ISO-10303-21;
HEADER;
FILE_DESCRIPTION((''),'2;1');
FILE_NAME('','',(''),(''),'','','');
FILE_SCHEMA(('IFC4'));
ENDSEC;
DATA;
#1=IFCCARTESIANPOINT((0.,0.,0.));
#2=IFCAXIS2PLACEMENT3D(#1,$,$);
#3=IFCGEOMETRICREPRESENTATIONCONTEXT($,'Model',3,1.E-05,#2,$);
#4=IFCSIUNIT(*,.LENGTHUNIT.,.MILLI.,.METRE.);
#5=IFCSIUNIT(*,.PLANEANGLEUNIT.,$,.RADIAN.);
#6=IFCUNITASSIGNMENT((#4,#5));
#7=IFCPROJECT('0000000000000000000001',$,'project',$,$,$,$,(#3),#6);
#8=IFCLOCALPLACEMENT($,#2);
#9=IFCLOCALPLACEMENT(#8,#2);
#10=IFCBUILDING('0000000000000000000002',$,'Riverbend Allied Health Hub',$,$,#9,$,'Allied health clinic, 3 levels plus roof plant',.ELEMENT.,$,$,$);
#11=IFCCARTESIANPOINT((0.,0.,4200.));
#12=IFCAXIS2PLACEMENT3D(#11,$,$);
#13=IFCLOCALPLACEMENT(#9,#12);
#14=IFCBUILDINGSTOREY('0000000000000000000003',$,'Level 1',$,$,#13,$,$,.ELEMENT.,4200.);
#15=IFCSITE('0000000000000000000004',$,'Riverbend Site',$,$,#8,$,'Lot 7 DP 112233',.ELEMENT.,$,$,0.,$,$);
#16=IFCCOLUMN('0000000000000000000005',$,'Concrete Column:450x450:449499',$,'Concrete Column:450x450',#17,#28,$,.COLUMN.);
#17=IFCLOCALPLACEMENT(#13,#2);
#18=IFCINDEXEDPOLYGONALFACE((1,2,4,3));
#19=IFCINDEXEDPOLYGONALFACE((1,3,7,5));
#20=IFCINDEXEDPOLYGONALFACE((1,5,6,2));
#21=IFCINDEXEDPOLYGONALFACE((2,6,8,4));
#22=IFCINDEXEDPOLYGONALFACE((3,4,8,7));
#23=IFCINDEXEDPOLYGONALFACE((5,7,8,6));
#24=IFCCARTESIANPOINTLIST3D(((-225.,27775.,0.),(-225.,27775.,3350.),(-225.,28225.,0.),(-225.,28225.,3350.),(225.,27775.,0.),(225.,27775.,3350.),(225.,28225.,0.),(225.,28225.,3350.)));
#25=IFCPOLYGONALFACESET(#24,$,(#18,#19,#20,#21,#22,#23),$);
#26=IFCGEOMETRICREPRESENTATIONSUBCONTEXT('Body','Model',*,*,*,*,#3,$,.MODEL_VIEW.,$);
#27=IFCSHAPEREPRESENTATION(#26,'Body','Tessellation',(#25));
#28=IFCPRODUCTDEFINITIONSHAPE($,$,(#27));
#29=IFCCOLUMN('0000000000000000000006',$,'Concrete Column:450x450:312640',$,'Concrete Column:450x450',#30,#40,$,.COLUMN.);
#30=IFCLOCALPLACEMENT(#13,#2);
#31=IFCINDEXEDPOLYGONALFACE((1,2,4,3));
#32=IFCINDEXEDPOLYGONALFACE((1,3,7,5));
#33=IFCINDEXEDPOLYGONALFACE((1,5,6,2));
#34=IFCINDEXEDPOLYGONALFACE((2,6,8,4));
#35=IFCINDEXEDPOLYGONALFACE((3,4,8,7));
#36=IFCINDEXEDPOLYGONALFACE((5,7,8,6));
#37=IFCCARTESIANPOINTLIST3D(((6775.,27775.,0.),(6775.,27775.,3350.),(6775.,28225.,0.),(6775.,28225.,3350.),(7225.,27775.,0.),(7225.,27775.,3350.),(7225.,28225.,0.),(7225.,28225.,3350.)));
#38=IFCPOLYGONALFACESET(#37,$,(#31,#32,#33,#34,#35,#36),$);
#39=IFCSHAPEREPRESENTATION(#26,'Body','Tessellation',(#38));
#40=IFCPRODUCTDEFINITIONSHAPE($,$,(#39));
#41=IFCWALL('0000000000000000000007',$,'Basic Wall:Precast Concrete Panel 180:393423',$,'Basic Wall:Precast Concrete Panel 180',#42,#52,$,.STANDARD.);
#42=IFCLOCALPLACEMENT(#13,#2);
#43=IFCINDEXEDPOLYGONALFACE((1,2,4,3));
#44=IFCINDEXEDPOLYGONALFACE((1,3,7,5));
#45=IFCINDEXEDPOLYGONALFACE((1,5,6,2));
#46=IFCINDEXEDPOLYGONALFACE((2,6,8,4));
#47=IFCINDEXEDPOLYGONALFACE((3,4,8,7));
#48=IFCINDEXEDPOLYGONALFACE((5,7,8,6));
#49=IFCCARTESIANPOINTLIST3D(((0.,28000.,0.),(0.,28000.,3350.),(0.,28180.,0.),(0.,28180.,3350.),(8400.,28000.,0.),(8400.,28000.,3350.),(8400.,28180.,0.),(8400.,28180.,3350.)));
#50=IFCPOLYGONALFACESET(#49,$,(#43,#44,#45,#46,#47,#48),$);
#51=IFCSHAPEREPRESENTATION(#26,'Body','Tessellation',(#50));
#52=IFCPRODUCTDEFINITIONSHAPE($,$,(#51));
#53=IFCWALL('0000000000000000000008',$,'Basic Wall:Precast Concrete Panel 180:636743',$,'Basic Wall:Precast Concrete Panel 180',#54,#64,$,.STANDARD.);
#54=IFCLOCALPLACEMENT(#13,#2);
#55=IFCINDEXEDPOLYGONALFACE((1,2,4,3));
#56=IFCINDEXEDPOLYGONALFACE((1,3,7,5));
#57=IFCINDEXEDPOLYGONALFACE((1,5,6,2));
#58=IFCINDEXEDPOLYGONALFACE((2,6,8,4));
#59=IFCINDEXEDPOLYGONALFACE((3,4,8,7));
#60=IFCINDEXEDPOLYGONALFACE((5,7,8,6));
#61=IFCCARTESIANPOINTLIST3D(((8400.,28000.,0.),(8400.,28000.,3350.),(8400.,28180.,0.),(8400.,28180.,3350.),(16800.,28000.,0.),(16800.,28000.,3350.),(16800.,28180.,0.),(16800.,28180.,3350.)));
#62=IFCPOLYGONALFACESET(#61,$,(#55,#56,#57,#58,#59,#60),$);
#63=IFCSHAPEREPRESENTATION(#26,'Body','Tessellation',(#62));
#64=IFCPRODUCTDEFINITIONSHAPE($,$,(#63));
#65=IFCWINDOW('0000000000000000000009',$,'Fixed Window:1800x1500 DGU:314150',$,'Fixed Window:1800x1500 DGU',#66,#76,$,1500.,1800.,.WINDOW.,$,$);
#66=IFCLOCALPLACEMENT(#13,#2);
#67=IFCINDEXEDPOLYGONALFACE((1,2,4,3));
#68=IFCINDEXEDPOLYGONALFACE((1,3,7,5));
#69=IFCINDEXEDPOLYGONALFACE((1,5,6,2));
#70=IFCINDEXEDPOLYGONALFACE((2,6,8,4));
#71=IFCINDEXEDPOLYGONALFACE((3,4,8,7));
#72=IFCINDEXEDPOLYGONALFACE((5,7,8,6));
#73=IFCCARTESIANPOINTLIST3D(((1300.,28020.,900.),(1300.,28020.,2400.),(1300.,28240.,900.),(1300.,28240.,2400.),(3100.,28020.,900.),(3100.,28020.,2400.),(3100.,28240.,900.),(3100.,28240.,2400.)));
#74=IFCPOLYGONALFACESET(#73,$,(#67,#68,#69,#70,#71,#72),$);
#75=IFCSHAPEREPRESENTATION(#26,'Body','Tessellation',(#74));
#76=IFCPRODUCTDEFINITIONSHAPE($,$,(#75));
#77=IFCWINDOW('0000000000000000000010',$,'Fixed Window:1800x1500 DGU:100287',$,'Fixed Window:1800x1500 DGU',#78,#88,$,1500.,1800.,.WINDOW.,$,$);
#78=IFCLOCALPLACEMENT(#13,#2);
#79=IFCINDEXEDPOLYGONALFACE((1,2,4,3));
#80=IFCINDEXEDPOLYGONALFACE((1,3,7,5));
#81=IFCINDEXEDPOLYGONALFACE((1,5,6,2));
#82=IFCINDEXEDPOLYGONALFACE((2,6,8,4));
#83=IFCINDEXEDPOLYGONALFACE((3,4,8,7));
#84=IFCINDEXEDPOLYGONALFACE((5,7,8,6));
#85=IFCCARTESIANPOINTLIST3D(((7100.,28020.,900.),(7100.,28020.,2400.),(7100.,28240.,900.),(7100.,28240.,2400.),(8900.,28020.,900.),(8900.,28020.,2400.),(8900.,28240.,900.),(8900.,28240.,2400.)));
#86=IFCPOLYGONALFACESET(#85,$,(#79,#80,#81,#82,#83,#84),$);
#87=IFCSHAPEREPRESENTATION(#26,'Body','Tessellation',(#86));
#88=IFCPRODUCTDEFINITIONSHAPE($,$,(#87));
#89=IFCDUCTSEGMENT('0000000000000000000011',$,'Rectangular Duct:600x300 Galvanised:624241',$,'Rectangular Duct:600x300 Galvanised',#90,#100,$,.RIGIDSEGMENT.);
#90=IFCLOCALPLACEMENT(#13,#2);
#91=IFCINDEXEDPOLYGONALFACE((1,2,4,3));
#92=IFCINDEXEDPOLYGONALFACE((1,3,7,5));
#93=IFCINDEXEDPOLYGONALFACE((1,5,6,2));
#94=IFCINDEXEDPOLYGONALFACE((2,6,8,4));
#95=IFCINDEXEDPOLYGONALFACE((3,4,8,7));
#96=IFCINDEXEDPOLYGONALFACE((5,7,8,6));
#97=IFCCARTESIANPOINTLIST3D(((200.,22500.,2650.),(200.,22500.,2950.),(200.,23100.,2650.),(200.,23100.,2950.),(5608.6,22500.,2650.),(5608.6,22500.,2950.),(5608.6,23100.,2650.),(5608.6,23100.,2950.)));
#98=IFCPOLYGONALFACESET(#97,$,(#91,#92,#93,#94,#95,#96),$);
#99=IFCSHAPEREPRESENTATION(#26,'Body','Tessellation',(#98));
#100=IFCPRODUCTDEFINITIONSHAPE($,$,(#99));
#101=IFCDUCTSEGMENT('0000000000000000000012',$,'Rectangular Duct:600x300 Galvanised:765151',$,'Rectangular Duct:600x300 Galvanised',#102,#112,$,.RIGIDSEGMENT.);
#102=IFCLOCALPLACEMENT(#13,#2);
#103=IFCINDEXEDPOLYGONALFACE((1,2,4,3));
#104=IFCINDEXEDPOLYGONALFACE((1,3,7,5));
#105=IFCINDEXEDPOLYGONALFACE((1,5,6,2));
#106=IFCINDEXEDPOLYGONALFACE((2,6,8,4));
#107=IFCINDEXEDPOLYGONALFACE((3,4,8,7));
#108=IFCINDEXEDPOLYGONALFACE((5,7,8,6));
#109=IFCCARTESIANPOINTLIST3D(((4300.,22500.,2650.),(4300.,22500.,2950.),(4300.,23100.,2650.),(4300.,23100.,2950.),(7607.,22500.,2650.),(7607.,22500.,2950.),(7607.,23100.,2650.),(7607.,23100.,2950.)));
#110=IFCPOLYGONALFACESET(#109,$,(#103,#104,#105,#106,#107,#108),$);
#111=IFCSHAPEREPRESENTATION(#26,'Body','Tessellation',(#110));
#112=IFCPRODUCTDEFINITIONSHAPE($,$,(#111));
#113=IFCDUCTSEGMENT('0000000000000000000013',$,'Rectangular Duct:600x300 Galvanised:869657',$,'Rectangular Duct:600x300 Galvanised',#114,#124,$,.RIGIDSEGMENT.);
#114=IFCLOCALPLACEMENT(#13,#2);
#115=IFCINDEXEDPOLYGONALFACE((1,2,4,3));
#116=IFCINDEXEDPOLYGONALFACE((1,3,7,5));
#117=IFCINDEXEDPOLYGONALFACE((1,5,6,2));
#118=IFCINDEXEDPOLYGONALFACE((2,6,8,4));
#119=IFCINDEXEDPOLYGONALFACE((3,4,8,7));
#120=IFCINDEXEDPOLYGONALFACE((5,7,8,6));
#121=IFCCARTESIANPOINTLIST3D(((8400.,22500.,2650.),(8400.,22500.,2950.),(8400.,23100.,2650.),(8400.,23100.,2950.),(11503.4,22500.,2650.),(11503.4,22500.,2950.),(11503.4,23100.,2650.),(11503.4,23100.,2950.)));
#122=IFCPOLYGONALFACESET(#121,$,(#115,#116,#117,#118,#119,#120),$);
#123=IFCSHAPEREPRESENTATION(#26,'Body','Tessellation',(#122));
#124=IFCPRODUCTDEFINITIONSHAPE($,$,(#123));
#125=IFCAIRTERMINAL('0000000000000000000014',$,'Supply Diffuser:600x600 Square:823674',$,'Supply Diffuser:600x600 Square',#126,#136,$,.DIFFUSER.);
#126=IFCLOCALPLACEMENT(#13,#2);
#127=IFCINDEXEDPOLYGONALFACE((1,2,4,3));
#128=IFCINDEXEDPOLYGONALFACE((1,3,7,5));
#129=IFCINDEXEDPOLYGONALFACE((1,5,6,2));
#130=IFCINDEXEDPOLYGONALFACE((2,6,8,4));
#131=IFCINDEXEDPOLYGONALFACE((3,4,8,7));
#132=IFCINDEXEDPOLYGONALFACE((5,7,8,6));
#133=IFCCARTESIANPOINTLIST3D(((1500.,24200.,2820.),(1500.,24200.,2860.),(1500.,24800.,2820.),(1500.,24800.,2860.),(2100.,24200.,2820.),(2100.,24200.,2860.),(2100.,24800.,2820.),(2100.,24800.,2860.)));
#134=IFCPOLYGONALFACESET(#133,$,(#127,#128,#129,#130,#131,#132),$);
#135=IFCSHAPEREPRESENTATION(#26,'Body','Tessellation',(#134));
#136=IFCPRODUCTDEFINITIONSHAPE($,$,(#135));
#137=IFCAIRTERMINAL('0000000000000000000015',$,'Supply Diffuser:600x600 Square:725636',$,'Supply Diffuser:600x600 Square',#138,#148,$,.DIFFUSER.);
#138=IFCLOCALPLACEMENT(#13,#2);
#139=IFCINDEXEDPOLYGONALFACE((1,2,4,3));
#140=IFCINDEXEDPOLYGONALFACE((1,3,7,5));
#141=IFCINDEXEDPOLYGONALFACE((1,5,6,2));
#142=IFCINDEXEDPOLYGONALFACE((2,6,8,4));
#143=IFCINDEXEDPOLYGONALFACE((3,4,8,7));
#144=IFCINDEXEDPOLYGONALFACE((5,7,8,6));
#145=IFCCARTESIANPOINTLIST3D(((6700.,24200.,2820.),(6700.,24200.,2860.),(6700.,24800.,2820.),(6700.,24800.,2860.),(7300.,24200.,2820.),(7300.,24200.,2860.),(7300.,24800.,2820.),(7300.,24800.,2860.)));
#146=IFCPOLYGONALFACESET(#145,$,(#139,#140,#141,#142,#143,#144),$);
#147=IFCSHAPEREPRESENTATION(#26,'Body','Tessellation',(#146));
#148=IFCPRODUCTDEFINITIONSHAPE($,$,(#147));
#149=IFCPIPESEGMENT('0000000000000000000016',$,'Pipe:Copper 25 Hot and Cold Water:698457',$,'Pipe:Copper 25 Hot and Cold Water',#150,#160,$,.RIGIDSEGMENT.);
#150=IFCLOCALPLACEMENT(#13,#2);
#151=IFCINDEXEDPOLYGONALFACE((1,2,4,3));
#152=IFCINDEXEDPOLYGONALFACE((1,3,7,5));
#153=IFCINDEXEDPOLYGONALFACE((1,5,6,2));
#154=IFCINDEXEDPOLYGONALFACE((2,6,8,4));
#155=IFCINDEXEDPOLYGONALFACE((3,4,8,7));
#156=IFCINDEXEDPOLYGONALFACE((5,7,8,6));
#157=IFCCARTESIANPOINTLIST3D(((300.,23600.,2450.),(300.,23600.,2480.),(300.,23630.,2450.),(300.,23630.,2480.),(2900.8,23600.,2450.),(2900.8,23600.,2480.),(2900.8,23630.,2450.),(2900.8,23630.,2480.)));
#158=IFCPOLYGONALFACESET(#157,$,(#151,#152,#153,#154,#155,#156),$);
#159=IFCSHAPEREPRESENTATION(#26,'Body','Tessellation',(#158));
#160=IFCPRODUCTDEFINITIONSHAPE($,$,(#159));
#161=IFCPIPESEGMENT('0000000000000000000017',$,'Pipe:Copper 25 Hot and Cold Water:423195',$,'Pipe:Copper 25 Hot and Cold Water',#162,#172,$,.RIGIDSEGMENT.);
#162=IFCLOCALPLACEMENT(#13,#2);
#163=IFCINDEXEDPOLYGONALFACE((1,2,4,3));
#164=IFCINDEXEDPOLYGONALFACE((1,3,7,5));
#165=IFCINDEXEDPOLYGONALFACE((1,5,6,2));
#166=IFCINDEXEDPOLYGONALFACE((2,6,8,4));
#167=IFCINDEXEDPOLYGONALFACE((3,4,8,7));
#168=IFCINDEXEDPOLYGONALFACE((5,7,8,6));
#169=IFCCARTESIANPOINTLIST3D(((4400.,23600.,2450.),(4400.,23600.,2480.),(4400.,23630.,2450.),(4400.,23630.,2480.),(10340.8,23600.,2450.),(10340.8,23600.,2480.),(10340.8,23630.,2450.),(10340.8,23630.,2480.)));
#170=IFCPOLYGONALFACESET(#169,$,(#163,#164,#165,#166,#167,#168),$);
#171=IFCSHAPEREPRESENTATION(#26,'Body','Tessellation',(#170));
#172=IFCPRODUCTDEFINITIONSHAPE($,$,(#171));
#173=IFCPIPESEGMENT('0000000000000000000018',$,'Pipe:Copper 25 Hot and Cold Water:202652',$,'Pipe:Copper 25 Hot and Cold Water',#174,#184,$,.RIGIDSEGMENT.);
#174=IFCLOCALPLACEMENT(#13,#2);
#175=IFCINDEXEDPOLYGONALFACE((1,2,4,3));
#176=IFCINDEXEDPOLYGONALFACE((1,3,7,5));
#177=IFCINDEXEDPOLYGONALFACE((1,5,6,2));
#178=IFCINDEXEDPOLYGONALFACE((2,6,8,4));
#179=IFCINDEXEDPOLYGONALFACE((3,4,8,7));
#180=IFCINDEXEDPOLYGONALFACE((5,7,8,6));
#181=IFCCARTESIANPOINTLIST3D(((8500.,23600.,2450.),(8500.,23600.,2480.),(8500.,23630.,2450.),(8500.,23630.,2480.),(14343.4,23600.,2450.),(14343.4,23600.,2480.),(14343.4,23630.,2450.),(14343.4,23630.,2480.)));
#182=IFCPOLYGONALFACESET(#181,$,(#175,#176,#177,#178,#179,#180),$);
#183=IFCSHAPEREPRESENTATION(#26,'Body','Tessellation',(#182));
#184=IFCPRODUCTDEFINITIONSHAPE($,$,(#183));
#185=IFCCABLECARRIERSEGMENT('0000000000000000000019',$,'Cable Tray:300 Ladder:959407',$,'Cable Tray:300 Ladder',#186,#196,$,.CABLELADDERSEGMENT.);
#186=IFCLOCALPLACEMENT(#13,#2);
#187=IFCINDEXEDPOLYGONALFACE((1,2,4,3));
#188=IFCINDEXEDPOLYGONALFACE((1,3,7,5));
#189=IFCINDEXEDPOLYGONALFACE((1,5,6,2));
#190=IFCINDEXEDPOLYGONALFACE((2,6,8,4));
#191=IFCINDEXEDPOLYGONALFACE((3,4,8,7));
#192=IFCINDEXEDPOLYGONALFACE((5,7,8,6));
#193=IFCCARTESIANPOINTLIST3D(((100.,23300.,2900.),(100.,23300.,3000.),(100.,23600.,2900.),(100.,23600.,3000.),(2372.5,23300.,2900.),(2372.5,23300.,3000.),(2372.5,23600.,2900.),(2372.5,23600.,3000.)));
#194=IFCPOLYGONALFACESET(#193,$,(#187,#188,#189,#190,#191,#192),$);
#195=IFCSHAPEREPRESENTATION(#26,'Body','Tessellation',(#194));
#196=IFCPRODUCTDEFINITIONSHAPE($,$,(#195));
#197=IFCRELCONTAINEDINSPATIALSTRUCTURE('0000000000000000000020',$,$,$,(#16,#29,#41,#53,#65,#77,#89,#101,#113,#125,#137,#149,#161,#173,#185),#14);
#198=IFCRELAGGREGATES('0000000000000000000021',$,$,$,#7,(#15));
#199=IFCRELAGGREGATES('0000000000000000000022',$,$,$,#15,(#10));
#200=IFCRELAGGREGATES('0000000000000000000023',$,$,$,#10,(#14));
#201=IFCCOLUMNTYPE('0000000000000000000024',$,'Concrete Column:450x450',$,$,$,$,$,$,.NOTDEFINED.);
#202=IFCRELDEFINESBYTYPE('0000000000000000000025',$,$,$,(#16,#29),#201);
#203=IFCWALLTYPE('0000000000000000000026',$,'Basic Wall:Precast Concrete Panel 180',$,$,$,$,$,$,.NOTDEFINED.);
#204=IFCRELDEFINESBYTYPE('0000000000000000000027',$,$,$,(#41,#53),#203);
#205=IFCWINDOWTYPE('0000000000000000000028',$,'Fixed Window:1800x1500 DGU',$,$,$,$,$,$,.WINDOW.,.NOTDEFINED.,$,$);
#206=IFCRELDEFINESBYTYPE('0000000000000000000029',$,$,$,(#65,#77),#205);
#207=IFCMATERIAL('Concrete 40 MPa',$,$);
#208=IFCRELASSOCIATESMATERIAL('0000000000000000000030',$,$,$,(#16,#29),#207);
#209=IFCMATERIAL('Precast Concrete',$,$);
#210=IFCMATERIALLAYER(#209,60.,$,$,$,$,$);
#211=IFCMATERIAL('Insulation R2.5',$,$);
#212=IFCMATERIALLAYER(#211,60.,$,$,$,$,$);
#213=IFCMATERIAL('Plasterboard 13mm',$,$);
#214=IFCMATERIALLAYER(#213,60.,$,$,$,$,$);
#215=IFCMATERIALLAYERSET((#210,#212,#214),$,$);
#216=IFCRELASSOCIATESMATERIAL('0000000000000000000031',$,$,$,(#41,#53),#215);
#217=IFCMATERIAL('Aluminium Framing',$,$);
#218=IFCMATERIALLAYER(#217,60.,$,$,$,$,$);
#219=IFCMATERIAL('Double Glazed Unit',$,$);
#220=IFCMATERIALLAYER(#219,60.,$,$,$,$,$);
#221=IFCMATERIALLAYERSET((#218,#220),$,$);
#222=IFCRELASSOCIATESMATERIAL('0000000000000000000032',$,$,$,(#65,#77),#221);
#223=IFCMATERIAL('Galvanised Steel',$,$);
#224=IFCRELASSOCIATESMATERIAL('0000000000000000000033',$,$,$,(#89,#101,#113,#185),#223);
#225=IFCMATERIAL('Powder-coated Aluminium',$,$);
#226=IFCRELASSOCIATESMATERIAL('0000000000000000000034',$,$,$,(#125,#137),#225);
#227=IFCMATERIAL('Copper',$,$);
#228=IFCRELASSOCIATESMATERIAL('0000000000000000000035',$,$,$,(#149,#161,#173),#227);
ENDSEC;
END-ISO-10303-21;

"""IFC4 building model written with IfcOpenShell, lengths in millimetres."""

from ifc_helpers import new_model, si_unit, frame, frame_2d, origin, place, context, subcontext, project, spatial, rectangle, extrude, material, layer, layer_set, layer_usage, type_object, element, save


model = new_model("IFC4")

# Units and contexts
model_context = context("Model", 3, precision=1e-05, world=origin())
body_context = subcontext(model_context, "Body", "Model", "MODEL_VIEW")
ifc_project = project(units=[si_unit("LENGTHUNIT", "METRE", prefix="MILLI"), si_unit("PLANEANGLEUNIT", "RADIAN")], contexts=[model_context])

# Site, building, storey
site_placement = place(None, origin())
site = spatial("IfcSite", under=ifc_project, at=site_placement, Name="Riverbend Site", LongName="Lot 7 DP 112233", CompositionType="ELEMENT", RefElevation=0.0)
building_placement = place(site_placement, origin())
building = spatial("IfcBuilding", under=site, at=building_placement, Name="Riverbend Allied Health Hub", LongName="Allied health clinic, 3 levels plus roof plant", CompositionType="ELEMENT")
storey_placement = place(building_placement, frame((0.0, 0.0, 4200.0)))
storey = spatial("IfcBuildingStorey", under=building, at=storey_placement, Name="Level 1", CompositionType="ELEMENT", Elevation=4200.0)

# Columns
ifc_material_1 = material(Name="Concrete 40 MPa")
column_type = type_object("IfcColumnType", Name="Concrete Column:450x450", PredefinedType="NOTDEFINED")
for number, where, name in (
    (1, (-225.0, 27775.0, 0.0), "Concrete Column:450x450:449499"),
    (2, (6775.0, 27775.0, 0.0), "Concrete Column:450x450:312640"),
):
    element("IfcColumn", number, at=place(storey_placement, frame(where)), inside=storey, type_object=column_type, material=ifc_material_1, Name=name, ObjectType="Concrete Column:450x450", PredefinedType="COLUMN", context=body_context, shape_type="SweptSolid", body=[
        extrude(rectangle(XDim=450.0, YDim=450.0, at=frame_2d((225.0, 225.0))), origin(), (0.0, 0.0, 1.0), 3350.0),
    ])

# Walls
ifc_material_2 = material(Name="Precast Concrete")
ifc_layer_1 = layer(ifc_material_2, 60.0)
ifc_material_3 = material(Name="Insulation R2.5")
ifc_layer_2 = layer(ifc_material_3, 60.0)
ifc_material_4 = material(Name="Plasterboard 13mm")
ifc_layer_3 = layer(ifc_material_4, 60.0)
ifc_layer_set_1 = layer_set([ifc_layer_1, ifc_layer_2, ifc_layer_3])
ifc_layer_usage_1 = layer_usage(ifc_layer_set_1, "AXIS2", "POSITIVE", 0.0)
wall_type = type_object("IfcWallType", Name="Basic Wall:Precast Concrete Panel 180", PredefinedType="NOTDEFINED")
for number, where, name in (
    (3, (0.0, 28000.0, 0.0), "Basic Wall:Precast Concrete Panel 180:393423"),
    (4, (8400.0, 28000.0, 0.0), "Basic Wall:Precast Concrete Panel 180:636743"),
):
    element("IfcWall", number, at=place(storey_placement, frame(where)), inside=storey, type_object=wall_type, material=ifc_layer_usage_1, Name=name, ObjectType="Basic Wall:Precast Concrete Panel 180", PredefinedType="STANDARD", context=body_context, shape_type="SweptSolid", body=[
        extrude(rectangle(XDim=8400.0, YDim=180.0, at=frame_2d((4200.0, 90.0))), origin(), (0.0, 0.0, 1.0), 3350.0),
    ])

# Windows
ifc_material_5 = material(Name="Aluminium Framing")
ifc_layer_4 = layer(ifc_material_5, 60.0)
ifc_material_6 = material(Name="Double Glazed Unit")
ifc_layer_5 = layer(ifc_material_6, 60.0)
ifc_layer_set_2 = layer_set([ifc_layer_4, ifc_layer_5])
ifc_layer_usage_2 = layer_usage(ifc_layer_set_2, "AXIS2", "POSITIVE", 0.0)
window_type = type_object("IfcWindowType", Name="Fixed Window:1800x1500 DGU", PartitioningType="NOTDEFINED", PredefinedType="WINDOW")
for number, where, name in (
    (5, (1300.0, 28020.0, 900.0), "Fixed Window:1800x1500 DGU:314150"),
    (6, (7100.0, 28020.0, 900.0), "Fixed Window:1800x1500 DGU:100287"),
):
    element("IfcWindow", number, at=place(storey_placement, frame(where)), inside=storey, type_object=window_type, material=ifc_layer_usage_2, Name=name, ObjectType="Fixed Window:1800x1500 DGU", OverallHeight=1500.0, OverallWidth=1800.0, PredefinedType="WINDOW", context=body_context, shape_type="SweptSolid", body=[
        extrude(rectangle(XDim=1800.0, YDim=220.0, at=frame_2d((900.0, 110.0))), origin(), (0.0, 0.0, 1.0), 1500.0),
    ])

# Duct segments
ifc_material_7 = material(Name="Galvanised Steel")
duct_segment_1_placement = place(storey_placement, frame((200.0, 22500.0, 2650.0)))
element("IfcDuctSegment", 7, at=duct_segment_1_placement, inside=storey, material=ifc_material_7, Name="Rectangular Duct:600x300 Galvanised:624241", ObjectType="Rectangular Duct:600x300 Galvanised", PredefinedType="RIGIDSEGMENT", context=body_context, shape_type="SweptSolid", body=[
    extrude(rectangle(XDim=5408.6, YDim=600.0, at=frame_2d((2704.3, 300.0))), origin(), (0.0, 0.0, 1.0), 300.0),
])
duct_segment_2_placement = place(storey_placement, frame((4300.0, 22500.0, 2650.0)))
element("IfcDuctSegment", 8, at=duct_segment_2_placement, inside=storey, material=ifc_material_7, Name="Rectangular Duct:600x300 Galvanised:765151", ObjectType="Rectangular Duct:600x300 Galvanised", PredefinedType="RIGIDSEGMENT", context=body_context, shape_type="SweptSolid", body=[
    extrude(rectangle(XDim=3307.0, YDim=600.0, at=frame_2d((1653.5, 300.0))), origin(), (0.0, 0.0, 1.0), 300.0),
])
duct_segment_3_placement = place(storey_placement, frame((8400.0, 22500.0, 2650.0)))
element("IfcDuctSegment", 9, at=duct_segment_3_placement, inside=storey, material=ifc_material_7, Name="Rectangular Duct:600x300 Galvanised:869657", ObjectType="Rectangular Duct:600x300 Galvanised", PredefinedType="RIGIDSEGMENT", context=body_context, shape_type="SweptSolid", body=[
    extrude(rectangle(XDim=3103.4, YDim=600.0, at=frame_2d((1551.7, 300.0))), origin(), (0.0, 0.0, 1.0), 300.0),
])

# Air terminals
ifc_material_8 = material(Name="Powder-coated Aluminium")
for number, where, name in (
    (10, (1500.0, 24200.0, 2820.0), "Supply Diffuser:600x600 Square:823674"),
    (11, (6700.0, 24200.0, 2820.0), "Supply Diffuser:600x600 Square:725636"),
):
    element("IfcAirTerminal", number, at=place(storey_placement, frame(where)), inside=storey, material=ifc_material_8, Name=name, ObjectType="Supply Diffuser:600x600 Square", PredefinedType="DIFFUSER", context=body_context, shape_type="SweptSolid", body=[
        extrude(rectangle(XDim=600.0, YDim=600.0, at=frame_2d((300.0, 300.0))), origin(), (0.0, 0.0, 1.0), 40.0),
    ])

# Pipe segments
ifc_material_9 = material(Name="Copper")
pipe_segment_1_placement = place(storey_placement, frame((300.0, 23600.0, 2450.0)))
element("IfcPipeSegment", 12, at=pipe_segment_1_placement, inside=storey, material=ifc_material_9, Name="Pipe:Copper 25 Hot and Cold Water:698457", ObjectType="Pipe:Copper 25 Hot and Cold Water", PredefinedType="RIGIDSEGMENT", context=body_context, shape_type="SweptSolid", body=[
    extrude(rectangle(XDim=2600.8, YDim=30.0, at=frame_2d((1300.4, 15.0))), origin(), (0.0, 0.0, 1.0), 30.0),
])
pipe_segment_2_placement = place(storey_placement, frame((4400.0, 23600.0, 2450.0)))
element("IfcPipeSegment", 13, at=pipe_segment_2_placement, inside=storey, material=ifc_material_9, Name="Pipe:Copper 25 Hot and Cold Water:423195", ObjectType="Pipe:Copper 25 Hot and Cold Water", PredefinedType="RIGIDSEGMENT", context=body_context, shape_type="SweptSolid", body=[
    extrude(rectangle(XDim=5940.8, YDim=30.0, at=frame_2d((2970.4, 15.0))), origin(), (0.0, 0.0, 1.0), 30.0),
])
pipe_segment_3_placement = place(storey_placement, frame((8500.0, 23600.0, 2450.0)))
element("IfcPipeSegment", 14, at=pipe_segment_3_placement, inside=storey, material=ifc_material_9, Name="Pipe:Copper 25 Hot and Cold Water:202652", ObjectType="Pipe:Copper 25 Hot and Cold Water", PredefinedType="RIGIDSEGMENT", context=body_context, shape_type="SweptSolid", body=[
    extrude(rectangle(XDim=5843.4, YDim=30.0, at=frame_2d((2921.7, 15.0))), origin(), (0.0, 0.0, 1.0), 30.0),
])

# Cable carrier segment
cable_carrier_segment_1_placement = place(storey_placement, frame((100.0, 23300.0, 2900.0)))
element("IfcCableCarrierSegment", 15, at=cable_carrier_segment_1_placement, inside=storey, material=ifc_material_7, Name="Cable Tray:300 Ladder:959407", ObjectType="Cable Tray:300 Ladder", PredefinedType="CABLELADDERSEGMENT", context=body_context, shape_type="SweptSolid", body=[
    extrude(rectangle(XDim=2272.5, YDim=300.0, at=frame_2d((1136.3, 150.0))), origin(), (0.0, 0.0, 1.0), 100.0),
])

save(model, "model.ifc")
